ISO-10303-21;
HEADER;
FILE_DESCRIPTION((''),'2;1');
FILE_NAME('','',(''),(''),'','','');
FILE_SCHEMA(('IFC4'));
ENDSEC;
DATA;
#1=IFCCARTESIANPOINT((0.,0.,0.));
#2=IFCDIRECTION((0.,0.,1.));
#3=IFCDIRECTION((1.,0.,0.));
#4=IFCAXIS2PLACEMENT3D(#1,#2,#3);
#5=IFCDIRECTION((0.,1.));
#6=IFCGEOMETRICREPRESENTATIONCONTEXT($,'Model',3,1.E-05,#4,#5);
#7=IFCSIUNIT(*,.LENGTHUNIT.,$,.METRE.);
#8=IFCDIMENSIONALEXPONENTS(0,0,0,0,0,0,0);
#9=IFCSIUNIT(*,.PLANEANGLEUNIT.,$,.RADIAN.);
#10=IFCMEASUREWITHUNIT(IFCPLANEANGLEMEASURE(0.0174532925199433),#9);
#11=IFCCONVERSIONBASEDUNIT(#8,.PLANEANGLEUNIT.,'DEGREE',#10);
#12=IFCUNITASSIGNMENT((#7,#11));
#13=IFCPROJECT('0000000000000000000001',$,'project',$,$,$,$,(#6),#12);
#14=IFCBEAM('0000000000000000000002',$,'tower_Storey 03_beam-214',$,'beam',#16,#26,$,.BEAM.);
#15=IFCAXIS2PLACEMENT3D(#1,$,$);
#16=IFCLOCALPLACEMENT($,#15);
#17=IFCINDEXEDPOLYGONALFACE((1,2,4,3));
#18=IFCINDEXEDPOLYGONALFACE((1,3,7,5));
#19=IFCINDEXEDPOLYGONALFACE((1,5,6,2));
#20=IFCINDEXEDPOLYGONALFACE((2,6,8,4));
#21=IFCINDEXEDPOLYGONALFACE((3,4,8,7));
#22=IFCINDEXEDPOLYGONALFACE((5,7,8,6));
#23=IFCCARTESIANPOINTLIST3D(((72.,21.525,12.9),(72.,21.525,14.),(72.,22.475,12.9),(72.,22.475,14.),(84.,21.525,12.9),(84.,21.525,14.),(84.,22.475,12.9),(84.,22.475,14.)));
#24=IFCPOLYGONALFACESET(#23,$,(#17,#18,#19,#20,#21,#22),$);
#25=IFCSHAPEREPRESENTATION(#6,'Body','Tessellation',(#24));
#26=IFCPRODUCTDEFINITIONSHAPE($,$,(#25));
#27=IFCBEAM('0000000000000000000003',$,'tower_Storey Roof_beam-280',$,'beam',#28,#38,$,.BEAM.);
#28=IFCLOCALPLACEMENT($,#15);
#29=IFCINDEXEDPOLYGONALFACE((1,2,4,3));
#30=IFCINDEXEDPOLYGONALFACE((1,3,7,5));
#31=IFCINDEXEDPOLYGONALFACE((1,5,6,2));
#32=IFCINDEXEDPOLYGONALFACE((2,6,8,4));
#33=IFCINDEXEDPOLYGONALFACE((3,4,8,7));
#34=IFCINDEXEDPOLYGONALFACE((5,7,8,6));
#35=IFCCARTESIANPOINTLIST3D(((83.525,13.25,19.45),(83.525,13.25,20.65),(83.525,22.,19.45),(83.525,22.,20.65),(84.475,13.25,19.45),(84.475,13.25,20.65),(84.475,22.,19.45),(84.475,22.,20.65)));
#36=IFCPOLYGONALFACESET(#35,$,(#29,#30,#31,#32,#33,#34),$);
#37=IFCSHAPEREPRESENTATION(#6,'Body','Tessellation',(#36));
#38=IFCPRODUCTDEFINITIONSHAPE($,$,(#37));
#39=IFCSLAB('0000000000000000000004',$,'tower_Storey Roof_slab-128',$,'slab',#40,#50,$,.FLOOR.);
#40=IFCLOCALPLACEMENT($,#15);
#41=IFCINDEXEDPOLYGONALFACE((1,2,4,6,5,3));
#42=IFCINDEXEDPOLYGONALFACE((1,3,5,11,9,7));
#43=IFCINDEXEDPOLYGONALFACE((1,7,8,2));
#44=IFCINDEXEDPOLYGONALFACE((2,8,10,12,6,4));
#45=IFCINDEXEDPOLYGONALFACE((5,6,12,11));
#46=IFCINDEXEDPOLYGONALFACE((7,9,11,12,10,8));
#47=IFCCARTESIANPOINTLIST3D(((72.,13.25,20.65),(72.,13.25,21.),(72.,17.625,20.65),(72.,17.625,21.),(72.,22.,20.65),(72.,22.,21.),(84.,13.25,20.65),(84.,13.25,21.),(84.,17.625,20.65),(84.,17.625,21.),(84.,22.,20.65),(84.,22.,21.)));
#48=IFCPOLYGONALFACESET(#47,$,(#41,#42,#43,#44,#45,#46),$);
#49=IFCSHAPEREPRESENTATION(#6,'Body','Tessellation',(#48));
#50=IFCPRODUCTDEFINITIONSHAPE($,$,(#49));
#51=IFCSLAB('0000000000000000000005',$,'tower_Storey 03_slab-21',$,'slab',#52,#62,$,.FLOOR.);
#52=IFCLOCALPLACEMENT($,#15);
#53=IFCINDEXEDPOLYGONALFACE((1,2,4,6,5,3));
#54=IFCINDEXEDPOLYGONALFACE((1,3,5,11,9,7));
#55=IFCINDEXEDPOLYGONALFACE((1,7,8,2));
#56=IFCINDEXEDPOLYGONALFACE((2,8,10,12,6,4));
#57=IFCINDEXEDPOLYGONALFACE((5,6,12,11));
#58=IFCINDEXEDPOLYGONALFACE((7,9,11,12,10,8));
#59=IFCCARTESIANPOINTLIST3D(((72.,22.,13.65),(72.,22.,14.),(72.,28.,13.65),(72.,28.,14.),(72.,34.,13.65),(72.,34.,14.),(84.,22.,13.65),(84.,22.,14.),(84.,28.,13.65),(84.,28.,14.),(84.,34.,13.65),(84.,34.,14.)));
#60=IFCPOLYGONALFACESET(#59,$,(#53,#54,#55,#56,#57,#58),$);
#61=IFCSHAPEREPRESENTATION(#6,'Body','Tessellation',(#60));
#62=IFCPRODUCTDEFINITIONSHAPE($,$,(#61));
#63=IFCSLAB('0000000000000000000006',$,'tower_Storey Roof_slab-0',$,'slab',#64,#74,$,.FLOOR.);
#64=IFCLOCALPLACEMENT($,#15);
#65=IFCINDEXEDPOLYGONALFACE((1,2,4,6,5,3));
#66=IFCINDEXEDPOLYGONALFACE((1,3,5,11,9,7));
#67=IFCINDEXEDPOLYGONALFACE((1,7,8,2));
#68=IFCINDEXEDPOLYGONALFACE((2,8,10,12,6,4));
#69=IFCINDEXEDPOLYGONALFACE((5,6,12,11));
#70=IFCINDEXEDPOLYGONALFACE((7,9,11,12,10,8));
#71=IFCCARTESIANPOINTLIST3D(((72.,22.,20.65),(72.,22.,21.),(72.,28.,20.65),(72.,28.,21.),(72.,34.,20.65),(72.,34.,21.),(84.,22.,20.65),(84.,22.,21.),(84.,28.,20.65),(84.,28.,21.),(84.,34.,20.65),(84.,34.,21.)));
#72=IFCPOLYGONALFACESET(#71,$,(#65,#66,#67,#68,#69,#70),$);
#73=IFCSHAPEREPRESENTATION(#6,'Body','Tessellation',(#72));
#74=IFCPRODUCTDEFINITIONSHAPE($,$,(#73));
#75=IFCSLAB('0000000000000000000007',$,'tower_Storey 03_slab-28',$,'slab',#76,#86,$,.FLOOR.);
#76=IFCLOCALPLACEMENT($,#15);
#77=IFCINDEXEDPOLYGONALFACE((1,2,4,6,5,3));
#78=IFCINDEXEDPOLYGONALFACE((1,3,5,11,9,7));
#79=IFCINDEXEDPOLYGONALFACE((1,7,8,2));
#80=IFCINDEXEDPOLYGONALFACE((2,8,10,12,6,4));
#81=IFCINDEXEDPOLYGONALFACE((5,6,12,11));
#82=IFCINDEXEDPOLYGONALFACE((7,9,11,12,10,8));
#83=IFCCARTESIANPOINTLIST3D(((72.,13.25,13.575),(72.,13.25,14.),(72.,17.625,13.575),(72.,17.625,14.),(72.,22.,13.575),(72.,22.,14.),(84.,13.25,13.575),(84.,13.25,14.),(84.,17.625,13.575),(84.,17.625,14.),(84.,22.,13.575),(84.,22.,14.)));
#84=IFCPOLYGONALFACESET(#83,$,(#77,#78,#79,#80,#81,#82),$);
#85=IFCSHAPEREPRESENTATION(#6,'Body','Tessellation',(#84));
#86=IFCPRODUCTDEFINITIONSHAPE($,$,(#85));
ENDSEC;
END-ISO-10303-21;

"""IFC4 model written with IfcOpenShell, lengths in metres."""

from ifc_helpers import new_model, entity, si_unit, converted_unit, direction, frame, origin_with_axes, place, context, project, polyline, outline, extrude, element, save


model = new_model("IFC4")

# Units and contexts
model_context = context("Model", 3, precision=1e-05, world=origin_with_axes(), true_north=direction((0.0, 1.0)))
ifc_project = project(units=[si_unit("LENGTHUNIT", "METRE"), converted_unit("PLANEANGLEUNIT", "DEGREE", entity("IfcPlaneAngleMeasure", 0.0174532925199433), si_unit("PLANEANGLEUNIT", "RADIAN"), dimensions=[0, 0, 0, 0, 0, 0, 0])], contexts=[model_context])

# Shared definitions
placement_1 = place(None, origin_with_axes())
placement_2 = place(placement_1, frame((0.0, 0.0, 14.0), z_axis=(0.0, 0.0, 1.0), x_axis=(1.0, 0.0, 0.0)))

# Beams
placement_3 = place(placement_1, frame((0.0, 0.0, 21.0), z_axis=(0.0, 0.0, 1.0), x_axis=(1.0, 0.0, 0.0)))
beam_1_placement = place(placement_2, frame((72.0, 22.0, -0.55), z_axis=(1.0, 0.0, 0.0), x_axis=(0.0, 1.0, 0.0)))
element("IfcBeam", 1, at=beam_1_placement, Name="tower_Storey 03_beam-214", ObjectType="beam", PredefinedType="BEAM", context=model_context, body=[
    extrude(outline(polyline([(0.475, 0.55, 0.0), (-0.475, 0.55, 0.0), (-0.475, -0.55, 0.0), (0.475, -0.55, 0.0), (0.475, 0.55, 0.0)])), origin_with_axes(), (0.0, 0.0, 1.0), 12.0),
])
beam_2_placement = place(placement_3, frame((84.0, 13.25, -0.95), z_axis=(0.0, 1.0, 0.0), x_axis=(-1.0, 0.0, 0.0)))
element("IfcBeam", 2, at=beam_2_placement, Name="tower_Storey Roof_beam-280", ObjectType="beam", PredefinedType="BEAM", context=model_context, body=[
    extrude(outline(polyline([(0.475, 0.6, 0.0), (-0.475, 0.6, 0.0), (-0.475, -0.6, 0.0), (0.475, -0.6, 0.0), (0.475, 0.6, 0.0)])), origin_with_axes(), (0.0, 0.0, 1.0), 8.75),
])

# Slabs
slab_1_placement = place(placement_3, frame((78.0, 17.625, -0.35), z_axis=(0.0, 0.0, 1.0), x_axis=(1.0, 0.0, 0.0)))
element("IfcSlab", 3, at=slab_1_placement, Name="tower_Storey Roof_slab-128", ObjectType="slab", PredefinedType="FLOOR", context=model_context, body=[
    extrude(outline(polyline([(-6.0, -4.375, 0.0), (6.0, -4.375, 0.0), (6.0, 0.0, 0.0), (6.0, 4.375, 0.0), (-6.0, 4.375, 0.0), (-6.0, 0.0, 0.0), (-6.0, -4.375, 0.0)])), origin_with_axes(), (0.0, 0.0, 1.0), 0.35),
])
slab_2_placement = place(placement_2, frame((78.0, 28.0, -0.35), z_axis=(0.0, 0.0, 1.0), x_axis=(1.0, 0.0, 0.0)))
element("IfcSlab", 4, at=slab_2_placement, Name="tower_Storey 03_slab-21", ObjectType="slab", PredefinedType="FLOOR", context=model_context, body=[
    extrude(outline(polyline([(-6.0, 0.0, 0.0), (-6.0, -6.0, 0.0), (6.0, -6.0, 0.0), (6.0, 0.0, 0.0), (6.0, 6.0, 0.0), (-6.0, 6.0, 0.0), (-6.0, 0.0, 0.0)])), origin_with_axes(), (0.0, 0.0, 1.0), 0.35),
])
slab_3_placement = place(placement_3, frame((78.0, 28.0, -0.35), z_axis=(0.0, 0.0, 1.0), x_axis=(1.0, 0.0, 0.0)))
element("IfcSlab", 5, at=slab_3_placement, Name="tower_Storey Roof_slab-0", ObjectType="slab", PredefinedType="FLOOR", context=model_context, body=[
    extrude(outline(polyline([(-6.0, 0.0, 0.0), (-6.0, -6.0, 0.0), (6.0, -6.0, 0.0), (6.0, 0.0, 0.0), (6.0, 6.0, 0.0), (-6.0, 6.0, 0.0), (-6.0, 0.0, 0.0)])), origin_with_axes(), (0.0, 0.0, 1.0), 0.35),
])
slab_4_placement = place(placement_2, frame((78.0, 17.625, -0.425), z_axis=(0.0, 0.0, 1.0), x_axis=(1.0, 0.0, 0.0)))
element("IfcSlab", 6, at=slab_4_placement, Name="tower_Storey 03_slab-28", ObjectType="slab", PredefinedType="FLOOR", context=model_context, body=[
    extrude(outline(polyline([(-6.0, -4.375, 0.0), (6.0, -4.375, 0.0), (6.0, 0.0, 0.0), (6.0, 4.375, 0.0), (-6.0, 4.375, 0.0), (-6.0, 0.0, 0.0), (-6.0, -4.375, 0.0)])), origin_with_axes(), (0.0, 0.0, 1.0), 0.425),
])

save(model, "model.ifc")
